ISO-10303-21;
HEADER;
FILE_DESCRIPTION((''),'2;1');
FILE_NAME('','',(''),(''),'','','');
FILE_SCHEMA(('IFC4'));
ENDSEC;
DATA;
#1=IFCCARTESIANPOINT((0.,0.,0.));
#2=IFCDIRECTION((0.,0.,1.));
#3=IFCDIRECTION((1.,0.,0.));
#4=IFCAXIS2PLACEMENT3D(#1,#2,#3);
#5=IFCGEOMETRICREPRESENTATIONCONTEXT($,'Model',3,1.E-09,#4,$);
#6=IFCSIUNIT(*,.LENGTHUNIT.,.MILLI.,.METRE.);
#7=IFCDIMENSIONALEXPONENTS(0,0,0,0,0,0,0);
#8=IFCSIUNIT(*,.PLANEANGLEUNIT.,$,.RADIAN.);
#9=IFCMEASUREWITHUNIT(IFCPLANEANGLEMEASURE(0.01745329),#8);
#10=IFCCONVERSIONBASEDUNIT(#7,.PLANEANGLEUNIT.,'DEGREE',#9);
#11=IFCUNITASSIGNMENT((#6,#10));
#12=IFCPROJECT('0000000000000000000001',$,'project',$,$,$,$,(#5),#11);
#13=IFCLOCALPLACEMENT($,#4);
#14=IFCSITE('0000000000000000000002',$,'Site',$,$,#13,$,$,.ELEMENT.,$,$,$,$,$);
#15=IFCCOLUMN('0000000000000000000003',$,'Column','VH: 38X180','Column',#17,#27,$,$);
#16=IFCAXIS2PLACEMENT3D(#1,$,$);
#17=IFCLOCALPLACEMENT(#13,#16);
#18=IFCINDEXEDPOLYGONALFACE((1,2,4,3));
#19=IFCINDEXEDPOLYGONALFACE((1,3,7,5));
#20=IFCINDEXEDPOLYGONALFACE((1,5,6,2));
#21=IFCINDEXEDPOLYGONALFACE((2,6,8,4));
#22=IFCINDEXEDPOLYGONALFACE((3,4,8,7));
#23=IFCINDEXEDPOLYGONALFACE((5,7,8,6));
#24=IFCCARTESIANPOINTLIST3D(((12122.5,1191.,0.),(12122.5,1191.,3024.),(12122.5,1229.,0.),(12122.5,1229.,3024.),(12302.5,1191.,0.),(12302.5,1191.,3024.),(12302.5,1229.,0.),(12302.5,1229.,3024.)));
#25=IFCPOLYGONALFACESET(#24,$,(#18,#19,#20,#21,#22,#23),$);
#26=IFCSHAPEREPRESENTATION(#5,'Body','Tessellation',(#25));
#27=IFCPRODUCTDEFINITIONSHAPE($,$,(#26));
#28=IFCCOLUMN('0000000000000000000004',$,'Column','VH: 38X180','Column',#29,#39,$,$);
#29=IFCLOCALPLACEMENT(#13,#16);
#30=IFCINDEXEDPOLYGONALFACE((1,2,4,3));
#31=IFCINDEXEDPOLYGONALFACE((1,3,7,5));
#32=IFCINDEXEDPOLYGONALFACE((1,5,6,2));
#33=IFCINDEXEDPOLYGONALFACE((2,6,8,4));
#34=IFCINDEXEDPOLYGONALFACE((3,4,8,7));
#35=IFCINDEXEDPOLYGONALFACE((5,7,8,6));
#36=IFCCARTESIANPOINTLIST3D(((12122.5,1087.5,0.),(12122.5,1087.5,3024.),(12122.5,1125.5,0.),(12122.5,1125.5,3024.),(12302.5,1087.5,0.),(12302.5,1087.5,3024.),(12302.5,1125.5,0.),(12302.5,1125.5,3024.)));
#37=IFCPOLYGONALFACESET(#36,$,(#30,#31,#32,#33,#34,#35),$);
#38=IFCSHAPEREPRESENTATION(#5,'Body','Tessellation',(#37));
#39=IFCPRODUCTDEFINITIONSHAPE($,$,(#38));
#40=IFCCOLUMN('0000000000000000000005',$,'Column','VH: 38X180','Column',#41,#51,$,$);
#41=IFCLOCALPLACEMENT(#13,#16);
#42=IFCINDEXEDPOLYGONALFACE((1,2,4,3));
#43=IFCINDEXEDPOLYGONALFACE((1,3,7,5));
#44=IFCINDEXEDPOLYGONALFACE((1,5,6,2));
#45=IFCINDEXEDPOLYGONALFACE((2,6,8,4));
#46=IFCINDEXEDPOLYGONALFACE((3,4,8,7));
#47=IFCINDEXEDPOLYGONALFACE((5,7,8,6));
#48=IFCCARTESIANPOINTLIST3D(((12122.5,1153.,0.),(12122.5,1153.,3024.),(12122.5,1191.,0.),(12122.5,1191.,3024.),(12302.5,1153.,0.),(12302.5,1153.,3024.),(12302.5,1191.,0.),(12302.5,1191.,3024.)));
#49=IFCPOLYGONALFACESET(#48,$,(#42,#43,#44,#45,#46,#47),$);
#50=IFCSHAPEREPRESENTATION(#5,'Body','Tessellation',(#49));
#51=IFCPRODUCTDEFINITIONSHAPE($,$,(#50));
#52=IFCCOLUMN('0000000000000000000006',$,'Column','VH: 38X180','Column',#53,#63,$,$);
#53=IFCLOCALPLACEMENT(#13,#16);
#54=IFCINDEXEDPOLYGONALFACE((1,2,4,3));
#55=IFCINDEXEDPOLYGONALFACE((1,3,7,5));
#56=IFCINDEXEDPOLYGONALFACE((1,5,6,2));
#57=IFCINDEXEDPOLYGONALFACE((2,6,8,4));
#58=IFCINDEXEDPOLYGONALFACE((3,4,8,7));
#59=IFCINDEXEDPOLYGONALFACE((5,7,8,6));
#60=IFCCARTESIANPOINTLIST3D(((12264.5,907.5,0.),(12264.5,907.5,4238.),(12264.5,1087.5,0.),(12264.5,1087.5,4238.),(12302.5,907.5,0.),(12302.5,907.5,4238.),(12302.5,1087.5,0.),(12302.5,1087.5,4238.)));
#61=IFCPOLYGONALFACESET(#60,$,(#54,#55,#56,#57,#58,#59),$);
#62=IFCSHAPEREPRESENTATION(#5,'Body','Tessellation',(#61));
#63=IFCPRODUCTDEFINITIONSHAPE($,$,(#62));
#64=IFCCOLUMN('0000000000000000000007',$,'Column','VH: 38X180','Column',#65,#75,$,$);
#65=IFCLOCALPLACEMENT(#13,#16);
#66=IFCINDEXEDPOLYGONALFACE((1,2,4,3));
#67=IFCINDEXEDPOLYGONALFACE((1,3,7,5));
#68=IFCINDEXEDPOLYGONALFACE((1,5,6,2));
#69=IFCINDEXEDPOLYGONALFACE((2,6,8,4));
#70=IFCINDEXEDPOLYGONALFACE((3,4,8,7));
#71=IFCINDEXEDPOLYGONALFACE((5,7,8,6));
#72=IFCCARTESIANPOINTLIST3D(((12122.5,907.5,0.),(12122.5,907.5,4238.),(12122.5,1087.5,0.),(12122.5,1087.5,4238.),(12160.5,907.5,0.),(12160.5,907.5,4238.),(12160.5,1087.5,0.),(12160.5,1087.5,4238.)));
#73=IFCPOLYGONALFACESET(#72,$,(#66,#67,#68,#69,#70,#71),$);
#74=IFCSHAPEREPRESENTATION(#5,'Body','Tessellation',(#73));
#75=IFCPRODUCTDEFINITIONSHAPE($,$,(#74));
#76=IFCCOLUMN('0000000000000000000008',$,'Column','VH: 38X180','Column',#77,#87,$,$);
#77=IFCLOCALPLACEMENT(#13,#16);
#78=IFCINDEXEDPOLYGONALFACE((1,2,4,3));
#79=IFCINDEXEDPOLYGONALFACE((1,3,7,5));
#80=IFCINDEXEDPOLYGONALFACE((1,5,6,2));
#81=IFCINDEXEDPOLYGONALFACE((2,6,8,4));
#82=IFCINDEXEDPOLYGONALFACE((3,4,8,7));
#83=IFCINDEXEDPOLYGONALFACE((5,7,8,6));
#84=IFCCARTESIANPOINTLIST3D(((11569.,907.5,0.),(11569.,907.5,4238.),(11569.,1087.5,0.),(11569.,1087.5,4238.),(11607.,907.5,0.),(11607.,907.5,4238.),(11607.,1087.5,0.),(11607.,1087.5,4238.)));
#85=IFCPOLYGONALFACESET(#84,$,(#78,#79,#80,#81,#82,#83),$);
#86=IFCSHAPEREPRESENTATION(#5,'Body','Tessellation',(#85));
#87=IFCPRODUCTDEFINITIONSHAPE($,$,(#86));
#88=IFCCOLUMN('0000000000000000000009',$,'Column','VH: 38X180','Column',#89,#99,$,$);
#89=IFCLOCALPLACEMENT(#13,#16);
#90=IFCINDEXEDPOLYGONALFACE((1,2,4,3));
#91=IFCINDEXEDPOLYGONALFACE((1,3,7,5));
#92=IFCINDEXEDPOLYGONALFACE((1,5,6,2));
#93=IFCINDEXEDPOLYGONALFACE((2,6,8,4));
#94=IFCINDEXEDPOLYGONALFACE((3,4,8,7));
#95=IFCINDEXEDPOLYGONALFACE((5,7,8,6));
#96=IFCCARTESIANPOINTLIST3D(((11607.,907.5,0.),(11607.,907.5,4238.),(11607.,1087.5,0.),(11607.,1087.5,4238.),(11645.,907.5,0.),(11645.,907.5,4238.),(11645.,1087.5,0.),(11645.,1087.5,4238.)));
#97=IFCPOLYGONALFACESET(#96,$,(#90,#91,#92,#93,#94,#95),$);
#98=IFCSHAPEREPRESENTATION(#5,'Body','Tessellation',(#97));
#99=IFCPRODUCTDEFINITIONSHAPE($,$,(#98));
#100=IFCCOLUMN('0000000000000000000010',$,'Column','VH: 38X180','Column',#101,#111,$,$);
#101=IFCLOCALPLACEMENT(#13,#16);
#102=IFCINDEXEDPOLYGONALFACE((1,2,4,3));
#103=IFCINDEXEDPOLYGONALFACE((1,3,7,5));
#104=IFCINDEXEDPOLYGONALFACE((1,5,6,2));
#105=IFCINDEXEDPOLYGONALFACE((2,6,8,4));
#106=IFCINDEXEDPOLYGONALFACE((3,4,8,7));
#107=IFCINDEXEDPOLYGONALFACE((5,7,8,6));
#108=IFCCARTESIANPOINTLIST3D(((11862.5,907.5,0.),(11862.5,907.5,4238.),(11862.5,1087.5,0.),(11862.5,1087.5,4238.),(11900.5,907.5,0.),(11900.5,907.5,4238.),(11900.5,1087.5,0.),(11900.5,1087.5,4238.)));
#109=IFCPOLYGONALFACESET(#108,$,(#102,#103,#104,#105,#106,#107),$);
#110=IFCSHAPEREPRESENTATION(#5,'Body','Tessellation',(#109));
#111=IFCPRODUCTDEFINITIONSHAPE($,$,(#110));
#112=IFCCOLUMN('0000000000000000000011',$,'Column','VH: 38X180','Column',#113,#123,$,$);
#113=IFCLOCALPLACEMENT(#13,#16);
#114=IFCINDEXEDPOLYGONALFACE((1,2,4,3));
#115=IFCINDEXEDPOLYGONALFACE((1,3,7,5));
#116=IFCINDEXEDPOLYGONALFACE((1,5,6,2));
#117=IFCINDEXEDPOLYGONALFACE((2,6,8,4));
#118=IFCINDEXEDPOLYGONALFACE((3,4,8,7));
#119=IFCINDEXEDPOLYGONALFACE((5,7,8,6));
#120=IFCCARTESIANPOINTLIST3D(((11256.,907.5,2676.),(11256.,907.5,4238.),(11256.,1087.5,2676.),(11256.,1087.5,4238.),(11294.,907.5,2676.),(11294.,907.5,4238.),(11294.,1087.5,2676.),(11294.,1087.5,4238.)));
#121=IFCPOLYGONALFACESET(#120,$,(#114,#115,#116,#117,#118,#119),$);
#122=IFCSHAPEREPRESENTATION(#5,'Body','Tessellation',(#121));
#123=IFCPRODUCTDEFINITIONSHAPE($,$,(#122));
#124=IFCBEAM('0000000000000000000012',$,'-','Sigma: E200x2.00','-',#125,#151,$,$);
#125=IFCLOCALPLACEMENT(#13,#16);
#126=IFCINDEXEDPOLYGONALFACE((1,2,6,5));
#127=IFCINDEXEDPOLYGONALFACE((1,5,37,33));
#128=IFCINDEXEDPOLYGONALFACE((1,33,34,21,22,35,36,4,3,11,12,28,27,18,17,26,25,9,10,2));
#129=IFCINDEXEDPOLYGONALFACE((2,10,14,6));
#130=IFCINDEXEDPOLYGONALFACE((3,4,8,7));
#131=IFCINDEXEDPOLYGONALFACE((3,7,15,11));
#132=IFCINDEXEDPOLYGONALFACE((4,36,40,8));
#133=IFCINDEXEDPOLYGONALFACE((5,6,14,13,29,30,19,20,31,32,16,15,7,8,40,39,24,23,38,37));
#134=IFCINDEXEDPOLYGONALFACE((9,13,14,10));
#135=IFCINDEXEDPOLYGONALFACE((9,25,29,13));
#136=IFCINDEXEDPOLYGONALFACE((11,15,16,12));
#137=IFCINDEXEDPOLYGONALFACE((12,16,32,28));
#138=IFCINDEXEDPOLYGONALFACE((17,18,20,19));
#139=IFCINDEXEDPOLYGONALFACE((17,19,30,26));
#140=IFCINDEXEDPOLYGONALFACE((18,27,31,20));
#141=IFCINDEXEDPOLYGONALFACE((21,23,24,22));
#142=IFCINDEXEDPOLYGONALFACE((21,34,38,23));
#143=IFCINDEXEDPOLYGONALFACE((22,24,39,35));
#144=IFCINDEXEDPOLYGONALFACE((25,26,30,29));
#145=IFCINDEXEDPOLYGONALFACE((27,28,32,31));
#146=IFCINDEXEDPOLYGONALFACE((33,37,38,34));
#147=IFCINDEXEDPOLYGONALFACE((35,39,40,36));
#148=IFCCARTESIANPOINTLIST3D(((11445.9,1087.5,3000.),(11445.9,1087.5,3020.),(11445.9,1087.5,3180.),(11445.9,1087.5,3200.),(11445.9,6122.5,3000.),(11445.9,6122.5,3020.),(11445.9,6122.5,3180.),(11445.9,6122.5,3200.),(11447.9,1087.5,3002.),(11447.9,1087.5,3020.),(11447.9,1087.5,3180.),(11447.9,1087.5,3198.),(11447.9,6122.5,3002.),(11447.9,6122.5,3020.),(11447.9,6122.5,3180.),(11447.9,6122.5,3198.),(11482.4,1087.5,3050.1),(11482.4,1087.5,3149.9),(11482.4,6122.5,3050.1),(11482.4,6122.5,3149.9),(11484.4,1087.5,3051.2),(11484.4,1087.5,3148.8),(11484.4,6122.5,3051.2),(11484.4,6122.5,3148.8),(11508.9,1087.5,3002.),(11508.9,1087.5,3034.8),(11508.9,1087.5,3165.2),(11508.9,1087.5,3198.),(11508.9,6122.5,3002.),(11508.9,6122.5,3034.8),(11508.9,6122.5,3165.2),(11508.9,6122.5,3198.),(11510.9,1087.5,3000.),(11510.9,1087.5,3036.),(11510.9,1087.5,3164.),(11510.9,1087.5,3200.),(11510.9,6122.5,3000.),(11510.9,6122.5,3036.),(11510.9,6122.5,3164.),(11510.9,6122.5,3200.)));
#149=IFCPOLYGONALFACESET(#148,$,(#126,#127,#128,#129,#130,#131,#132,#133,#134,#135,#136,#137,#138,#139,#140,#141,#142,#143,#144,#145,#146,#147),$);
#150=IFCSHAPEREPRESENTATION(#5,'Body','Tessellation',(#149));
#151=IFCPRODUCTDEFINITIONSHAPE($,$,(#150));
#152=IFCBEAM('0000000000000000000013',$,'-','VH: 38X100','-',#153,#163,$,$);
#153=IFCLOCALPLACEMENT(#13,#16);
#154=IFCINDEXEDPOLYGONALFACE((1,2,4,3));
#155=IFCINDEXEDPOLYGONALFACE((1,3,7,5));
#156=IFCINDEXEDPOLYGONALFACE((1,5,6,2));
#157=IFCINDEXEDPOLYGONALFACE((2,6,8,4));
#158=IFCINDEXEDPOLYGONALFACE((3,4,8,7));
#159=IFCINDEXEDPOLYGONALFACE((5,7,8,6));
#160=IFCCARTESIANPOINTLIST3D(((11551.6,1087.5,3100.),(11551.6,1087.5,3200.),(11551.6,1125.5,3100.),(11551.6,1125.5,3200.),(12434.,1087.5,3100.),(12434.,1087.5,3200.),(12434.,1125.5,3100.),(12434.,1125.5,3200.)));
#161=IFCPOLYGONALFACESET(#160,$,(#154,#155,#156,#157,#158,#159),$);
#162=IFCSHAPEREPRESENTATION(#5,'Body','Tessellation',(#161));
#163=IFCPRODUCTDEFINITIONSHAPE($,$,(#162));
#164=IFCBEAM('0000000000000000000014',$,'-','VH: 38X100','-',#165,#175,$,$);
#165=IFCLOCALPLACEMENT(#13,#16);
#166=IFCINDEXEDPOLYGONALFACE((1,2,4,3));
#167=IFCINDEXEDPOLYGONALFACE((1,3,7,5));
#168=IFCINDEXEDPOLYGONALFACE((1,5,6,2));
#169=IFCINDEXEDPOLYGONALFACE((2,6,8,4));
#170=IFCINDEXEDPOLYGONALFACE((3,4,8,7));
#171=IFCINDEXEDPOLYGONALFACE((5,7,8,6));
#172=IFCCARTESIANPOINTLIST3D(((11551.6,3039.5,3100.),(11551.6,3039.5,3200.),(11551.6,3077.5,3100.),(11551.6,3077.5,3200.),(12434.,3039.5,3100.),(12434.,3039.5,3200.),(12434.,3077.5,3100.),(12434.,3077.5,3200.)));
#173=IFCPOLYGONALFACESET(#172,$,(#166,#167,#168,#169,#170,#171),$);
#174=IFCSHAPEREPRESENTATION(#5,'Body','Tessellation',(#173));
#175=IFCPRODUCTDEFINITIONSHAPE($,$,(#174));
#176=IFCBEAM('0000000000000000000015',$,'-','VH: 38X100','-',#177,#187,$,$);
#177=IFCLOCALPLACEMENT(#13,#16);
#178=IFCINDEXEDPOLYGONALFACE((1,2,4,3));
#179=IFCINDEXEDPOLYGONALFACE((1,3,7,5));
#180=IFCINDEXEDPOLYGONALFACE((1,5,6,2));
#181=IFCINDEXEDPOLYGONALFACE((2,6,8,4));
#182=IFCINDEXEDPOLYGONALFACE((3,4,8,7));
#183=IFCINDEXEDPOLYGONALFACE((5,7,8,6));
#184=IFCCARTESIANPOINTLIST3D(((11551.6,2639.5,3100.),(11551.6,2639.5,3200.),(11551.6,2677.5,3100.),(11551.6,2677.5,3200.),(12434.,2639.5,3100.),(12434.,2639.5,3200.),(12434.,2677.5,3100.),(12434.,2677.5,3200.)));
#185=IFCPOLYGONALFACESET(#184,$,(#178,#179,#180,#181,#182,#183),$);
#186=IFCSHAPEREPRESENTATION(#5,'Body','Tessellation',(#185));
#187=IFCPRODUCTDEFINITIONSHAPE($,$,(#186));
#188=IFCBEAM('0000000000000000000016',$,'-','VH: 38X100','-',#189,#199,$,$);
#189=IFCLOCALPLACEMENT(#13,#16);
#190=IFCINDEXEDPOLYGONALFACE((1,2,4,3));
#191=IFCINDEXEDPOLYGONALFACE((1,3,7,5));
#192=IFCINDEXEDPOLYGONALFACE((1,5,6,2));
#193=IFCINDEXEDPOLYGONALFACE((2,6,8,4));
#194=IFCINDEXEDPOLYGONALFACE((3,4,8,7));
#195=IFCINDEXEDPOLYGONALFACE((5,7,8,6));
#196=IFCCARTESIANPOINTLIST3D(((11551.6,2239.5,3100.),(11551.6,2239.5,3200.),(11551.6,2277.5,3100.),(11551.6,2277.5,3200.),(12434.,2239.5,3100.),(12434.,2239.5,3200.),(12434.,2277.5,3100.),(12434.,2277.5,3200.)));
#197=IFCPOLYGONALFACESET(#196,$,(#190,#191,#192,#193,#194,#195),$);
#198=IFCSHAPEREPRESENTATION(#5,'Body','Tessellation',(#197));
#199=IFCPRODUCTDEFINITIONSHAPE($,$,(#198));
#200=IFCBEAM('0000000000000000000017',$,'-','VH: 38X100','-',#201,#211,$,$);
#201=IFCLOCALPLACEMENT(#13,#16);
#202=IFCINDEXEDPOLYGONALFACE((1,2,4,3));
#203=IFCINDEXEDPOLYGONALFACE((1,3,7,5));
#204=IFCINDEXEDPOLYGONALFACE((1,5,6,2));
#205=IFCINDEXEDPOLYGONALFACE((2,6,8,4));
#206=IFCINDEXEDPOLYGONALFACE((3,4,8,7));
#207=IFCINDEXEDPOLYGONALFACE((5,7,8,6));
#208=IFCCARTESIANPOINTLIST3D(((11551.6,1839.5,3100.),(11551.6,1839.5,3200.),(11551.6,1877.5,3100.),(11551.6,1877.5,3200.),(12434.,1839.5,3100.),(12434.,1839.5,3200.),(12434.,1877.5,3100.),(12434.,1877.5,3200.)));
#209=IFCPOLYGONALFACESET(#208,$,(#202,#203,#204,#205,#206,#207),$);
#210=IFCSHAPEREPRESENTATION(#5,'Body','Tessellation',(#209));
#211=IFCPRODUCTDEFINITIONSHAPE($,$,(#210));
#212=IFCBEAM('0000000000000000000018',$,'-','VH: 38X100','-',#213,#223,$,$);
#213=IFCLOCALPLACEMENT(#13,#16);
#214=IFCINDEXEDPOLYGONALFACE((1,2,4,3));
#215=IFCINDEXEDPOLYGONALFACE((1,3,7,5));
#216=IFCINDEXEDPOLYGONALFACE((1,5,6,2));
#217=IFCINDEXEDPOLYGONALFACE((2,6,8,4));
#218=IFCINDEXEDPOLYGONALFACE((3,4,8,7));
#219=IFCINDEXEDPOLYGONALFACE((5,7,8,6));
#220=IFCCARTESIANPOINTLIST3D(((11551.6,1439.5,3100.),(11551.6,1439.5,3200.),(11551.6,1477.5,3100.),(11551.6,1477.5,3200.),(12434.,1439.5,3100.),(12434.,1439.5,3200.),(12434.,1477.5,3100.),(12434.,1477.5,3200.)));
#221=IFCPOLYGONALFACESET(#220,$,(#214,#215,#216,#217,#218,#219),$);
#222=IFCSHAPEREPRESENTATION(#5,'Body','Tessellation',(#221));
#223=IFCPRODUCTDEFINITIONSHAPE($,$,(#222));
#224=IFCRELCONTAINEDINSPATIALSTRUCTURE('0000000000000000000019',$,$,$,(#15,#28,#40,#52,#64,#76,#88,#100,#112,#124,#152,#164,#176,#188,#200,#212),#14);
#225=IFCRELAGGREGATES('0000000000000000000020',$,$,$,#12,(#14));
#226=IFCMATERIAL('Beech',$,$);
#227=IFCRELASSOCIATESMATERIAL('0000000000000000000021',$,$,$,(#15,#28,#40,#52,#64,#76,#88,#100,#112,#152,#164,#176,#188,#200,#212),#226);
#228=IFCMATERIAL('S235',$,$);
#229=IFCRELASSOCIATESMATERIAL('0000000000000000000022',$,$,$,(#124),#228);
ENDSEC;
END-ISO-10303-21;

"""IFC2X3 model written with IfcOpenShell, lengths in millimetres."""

from ifc_helpers import new_model, entity, si_unit, converted_unit, frame, origin, origin_with_axes, origin_2d, place, context, project, spatial, polyline, rectangle, outline, extrude, material, element, save


model = new_model("IFC2X3")

# Units and contexts
model_context = context("Model", 3, precision=1e-09, world=origin_with_axes())
ifc_project = project(units=[si_unit("LENGTHUNIT", "METRE", prefix="MILLI"), converted_unit("PLANEANGLEUNIT", "DEGREE", entity("IfcPlaneAngleMeasure", 0.01745329), si_unit("PLANEANGLEUNIT", "RADIAN"), dimensions=[0, 0, 0, 0, 0, 0, 0])], contexts=[model_context])

# Site
site_placement = place(None, origin_with_axes())
site = spatial("IfcSite", under=ifc_project, at=site_placement, Name="Site", CompositionType="ELEMENT")

# Columns
ifc_material_1 = material(Name="Beech")
for number, where, z_axis, x_axis, name in (
    (1, (12212.5, 1210.0, 0.0), (0.0, 0.0, -1.0), (0.0, -1.0, 0.0), "Column"),
    (2, (12212.5, 1106.5, 0.0), (0.0, 0.0, -1.0), (0.0, -1.0, 0.0), "Column"),
    (3, (12212.5, 1172.0, 0.0), (0.0, 0.0, -1.0), (0.0, -1.0, 0.0), "Column"),
):
    element("IfcColumn", number, at=place(None, frame(where, z_axis=z_axis, x_axis=x_axis)), inside=site, material=ifc_material_1, Name=name, Description="VH: 38X180", ObjectType="Column", context=model_context, shape_type="SweptSolid", body=[
        extrude(rectangle(XDim=38.0, YDim=180.0, at=origin_2d()), origin(), (0.0, 0.0, -1.0), 3024.0),
    ])
for number, where, z_axis, x_axis, name in (
    (4, (12283.5, 997.5, 0.0), (0.0, 0.0, -1.0), (-1.0, 0.0, 0.0), "Column"),
    (5, (12141.5, 997.5, 0.0), (0.0, 0.0, -1.0), (-1.0, 0.0, 0.0), "Column"),
    (6, (11588.0, 997.5, 0.0), (0.0, 0.0, -1.0), (-1.0, 0.0, 0.0), "Column"),
    (7, (11626.0, 997.5, 0.0), (0.0, 0.0, -1.0), (-1.0, 0.0, 0.0), "Column"),
    (8, (11881.5, 997.5, 0.0), (0.0, 0.0, -1.0), (-1.0, 0.0, 0.0), "Column"),
):
    element("IfcColumn", number, at=place(None, frame(where, z_axis=z_axis, x_axis=x_axis)), inside=site, material=ifc_material_1, Name=name, Description="VH: 38X180", ObjectType="Column", context=model_context, shape_type="SweptSolid", body=[
        extrude(rectangle(XDim=38.0, YDim=180.0, at=origin_2d()), origin(), (0.0, 0.0, -1.0), 4238.0),
    ])
column_placement = place(None, frame((11275.0, 997.5, 2676.0), z_axis=(0.0, 0.0, -1.0), x_axis=(-1.0, 0.0, 0.0)))
element("IfcColumn", 9, at=column_placement, inside=site, material=ifc_material_1, Name="Column", Description="VH: 38X180", ObjectType="Column", context=model_context, shape_type="SweptSolid", body=[
    extrude(rectangle(XDim=38.0, YDim=180.0, at=origin_2d()), origin(), (0.0, 0.0, -1.0), 1562.0),
])

# Beams
ifc_material_2 = material(Name="S235")
beam_1_placement = place(None, frame((11485.0, 1087.5, 3100.0), z_axis=(0.0, 1.0, 0.0), x_axis=(-1.0, 0.0, 0.0)))
element("IfcBeam", 10, at=beam_1_placement, inside=site, material=ifc_material_2, Name="-", Description="Sigma: E200x2.00", ObjectType="-", context=model_context, shape_type="SweptSolid", body=[
    extrude(outline(polyline([(39.1, -100.0), (39.1, -80.0), (37.1, -80.0), (37.1, -98.0), (-23.9, -98.0), (-23.9, -65.2), (2.6, -49.9), (2.6, 49.9), (-23.9, 65.2), (-23.9, 98.0), (37.1, 98.0), (37.1, 80.0), (39.1, 80.0), (39.1, 100.0), (-25.9, 100.0), (-25.9, 64.0), (0.6, 48.8), (0.6, -48.8), (-25.9, -64.0), (-25.9, -100.0), (39.1, -100.0)])), origin(), (0.0, 0.0, 1.0), 5035.0),
])
beam_2_placement = place(None, frame((11551.6, 1106.5, 3150.0), z_axis=(1.0, 0.000018, 0.0), x_axis=(-0.000018, 1.0, 0.0)))
element("IfcBeam", 11, at=beam_2_placement, inside=site, material=ifc_material_1, Name="-", Description="VH: 38X100", ObjectType="-", context=model_context, shape_type="SweptSolid", body=[
    extrude(rectangle(XDim=38.0, YDim=100.0, at=origin_2d()), origin(), (0.0, 0.0, 1.0), 882.4),
])
beam_3_placement = place(None, frame((11551.6, 3058.5, 3150.0), z_axis=(1.0, 0.000018, 0.0), x_axis=(-0.000018, 1.0, 0.0)))
element("IfcBeam", 12, at=beam_3_placement, inside=site, material=ifc_material_1, Name="-", Description="VH: 38X100", ObjectType="-", context=model_context, shape_type="SweptSolid", body=[
    extrude(rectangle(XDim=38.0, YDim=100.0, at=origin_2d()), origin(), (0.0, 0.0, 1.0), 882.4),
])
beam_4_placement = place(None, frame((11551.6, 2658.5, 3150.0), z_axis=(1.0, 0.000018, 0.0), x_axis=(-0.000018, 1.0, 0.0)))
element("IfcBeam", 13, at=beam_4_placement, inside=site, material=ifc_material_1, Name="-", Description="VH: 38X100", ObjectType="-", context=model_context, shape_type="SweptSolid", body=[
    extrude(rectangle(XDim=38.0, YDim=100.0, at=origin_2d()), origin(), (0.0, 0.0, 1.0), 882.4),
])
beam_5_placement = place(None, frame((11551.6, 2258.5, 3150.0), z_axis=(1.0, 0.000018, 0.0), x_axis=(-0.000018, 1.0, 0.0)))
element("IfcBeam", 14, at=beam_5_placement, inside=site, material=ifc_material_1, Name="-", Description="VH: 38X100", ObjectType="-", context=model_context, shape_type="SweptSolid", body=[
    extrude(rectangle(XDim=38.0, YDim=100.0, at=origin_2d()), origin(), (0.0, 0.0, 1.0), 882.4),
])
beam_6_placement = place(None, frame((11551.6, 1858.5, 3150.0), z_axis=(1.0, 0.000018, 0.0), x_axis=(-0.000018, 1.0, 0.0)))
element("IfcBeam", 15, at=beam_6_placement, inside=site, material=ifc_material_1, Name="-", Description="VH: 38X100", ObjectType="-", context=model_context, shape_type="SweptSolid", body=[
    extrude(rectangle(XDim=38.0, YDim=100.0, at=origin_2d()), origin(), (0.0, 0.0, 1.0), 882.4),
])
beam_7_placement = place(None, frame((11551.6, 1458.5, 3150.0), z_axis=(1.0, 0.000018, 0.0), x_axis=(-0.000018, 1.0, 0.0)))
element("IfcBeam", 16, at=beam_7_placement, inside=site, material=ifc_material_1, Name="-", Description="VH: 38X100", ObjectType="-", context=model_context, shape_type="SweptSolid", body=[
    extrude(rectangle(XDim=38.0, YDim=100.0, at=origin_2d()), origin(), (0.0, 0.0, 1.0), 882.4),
])

save(model, "model.ifc")
